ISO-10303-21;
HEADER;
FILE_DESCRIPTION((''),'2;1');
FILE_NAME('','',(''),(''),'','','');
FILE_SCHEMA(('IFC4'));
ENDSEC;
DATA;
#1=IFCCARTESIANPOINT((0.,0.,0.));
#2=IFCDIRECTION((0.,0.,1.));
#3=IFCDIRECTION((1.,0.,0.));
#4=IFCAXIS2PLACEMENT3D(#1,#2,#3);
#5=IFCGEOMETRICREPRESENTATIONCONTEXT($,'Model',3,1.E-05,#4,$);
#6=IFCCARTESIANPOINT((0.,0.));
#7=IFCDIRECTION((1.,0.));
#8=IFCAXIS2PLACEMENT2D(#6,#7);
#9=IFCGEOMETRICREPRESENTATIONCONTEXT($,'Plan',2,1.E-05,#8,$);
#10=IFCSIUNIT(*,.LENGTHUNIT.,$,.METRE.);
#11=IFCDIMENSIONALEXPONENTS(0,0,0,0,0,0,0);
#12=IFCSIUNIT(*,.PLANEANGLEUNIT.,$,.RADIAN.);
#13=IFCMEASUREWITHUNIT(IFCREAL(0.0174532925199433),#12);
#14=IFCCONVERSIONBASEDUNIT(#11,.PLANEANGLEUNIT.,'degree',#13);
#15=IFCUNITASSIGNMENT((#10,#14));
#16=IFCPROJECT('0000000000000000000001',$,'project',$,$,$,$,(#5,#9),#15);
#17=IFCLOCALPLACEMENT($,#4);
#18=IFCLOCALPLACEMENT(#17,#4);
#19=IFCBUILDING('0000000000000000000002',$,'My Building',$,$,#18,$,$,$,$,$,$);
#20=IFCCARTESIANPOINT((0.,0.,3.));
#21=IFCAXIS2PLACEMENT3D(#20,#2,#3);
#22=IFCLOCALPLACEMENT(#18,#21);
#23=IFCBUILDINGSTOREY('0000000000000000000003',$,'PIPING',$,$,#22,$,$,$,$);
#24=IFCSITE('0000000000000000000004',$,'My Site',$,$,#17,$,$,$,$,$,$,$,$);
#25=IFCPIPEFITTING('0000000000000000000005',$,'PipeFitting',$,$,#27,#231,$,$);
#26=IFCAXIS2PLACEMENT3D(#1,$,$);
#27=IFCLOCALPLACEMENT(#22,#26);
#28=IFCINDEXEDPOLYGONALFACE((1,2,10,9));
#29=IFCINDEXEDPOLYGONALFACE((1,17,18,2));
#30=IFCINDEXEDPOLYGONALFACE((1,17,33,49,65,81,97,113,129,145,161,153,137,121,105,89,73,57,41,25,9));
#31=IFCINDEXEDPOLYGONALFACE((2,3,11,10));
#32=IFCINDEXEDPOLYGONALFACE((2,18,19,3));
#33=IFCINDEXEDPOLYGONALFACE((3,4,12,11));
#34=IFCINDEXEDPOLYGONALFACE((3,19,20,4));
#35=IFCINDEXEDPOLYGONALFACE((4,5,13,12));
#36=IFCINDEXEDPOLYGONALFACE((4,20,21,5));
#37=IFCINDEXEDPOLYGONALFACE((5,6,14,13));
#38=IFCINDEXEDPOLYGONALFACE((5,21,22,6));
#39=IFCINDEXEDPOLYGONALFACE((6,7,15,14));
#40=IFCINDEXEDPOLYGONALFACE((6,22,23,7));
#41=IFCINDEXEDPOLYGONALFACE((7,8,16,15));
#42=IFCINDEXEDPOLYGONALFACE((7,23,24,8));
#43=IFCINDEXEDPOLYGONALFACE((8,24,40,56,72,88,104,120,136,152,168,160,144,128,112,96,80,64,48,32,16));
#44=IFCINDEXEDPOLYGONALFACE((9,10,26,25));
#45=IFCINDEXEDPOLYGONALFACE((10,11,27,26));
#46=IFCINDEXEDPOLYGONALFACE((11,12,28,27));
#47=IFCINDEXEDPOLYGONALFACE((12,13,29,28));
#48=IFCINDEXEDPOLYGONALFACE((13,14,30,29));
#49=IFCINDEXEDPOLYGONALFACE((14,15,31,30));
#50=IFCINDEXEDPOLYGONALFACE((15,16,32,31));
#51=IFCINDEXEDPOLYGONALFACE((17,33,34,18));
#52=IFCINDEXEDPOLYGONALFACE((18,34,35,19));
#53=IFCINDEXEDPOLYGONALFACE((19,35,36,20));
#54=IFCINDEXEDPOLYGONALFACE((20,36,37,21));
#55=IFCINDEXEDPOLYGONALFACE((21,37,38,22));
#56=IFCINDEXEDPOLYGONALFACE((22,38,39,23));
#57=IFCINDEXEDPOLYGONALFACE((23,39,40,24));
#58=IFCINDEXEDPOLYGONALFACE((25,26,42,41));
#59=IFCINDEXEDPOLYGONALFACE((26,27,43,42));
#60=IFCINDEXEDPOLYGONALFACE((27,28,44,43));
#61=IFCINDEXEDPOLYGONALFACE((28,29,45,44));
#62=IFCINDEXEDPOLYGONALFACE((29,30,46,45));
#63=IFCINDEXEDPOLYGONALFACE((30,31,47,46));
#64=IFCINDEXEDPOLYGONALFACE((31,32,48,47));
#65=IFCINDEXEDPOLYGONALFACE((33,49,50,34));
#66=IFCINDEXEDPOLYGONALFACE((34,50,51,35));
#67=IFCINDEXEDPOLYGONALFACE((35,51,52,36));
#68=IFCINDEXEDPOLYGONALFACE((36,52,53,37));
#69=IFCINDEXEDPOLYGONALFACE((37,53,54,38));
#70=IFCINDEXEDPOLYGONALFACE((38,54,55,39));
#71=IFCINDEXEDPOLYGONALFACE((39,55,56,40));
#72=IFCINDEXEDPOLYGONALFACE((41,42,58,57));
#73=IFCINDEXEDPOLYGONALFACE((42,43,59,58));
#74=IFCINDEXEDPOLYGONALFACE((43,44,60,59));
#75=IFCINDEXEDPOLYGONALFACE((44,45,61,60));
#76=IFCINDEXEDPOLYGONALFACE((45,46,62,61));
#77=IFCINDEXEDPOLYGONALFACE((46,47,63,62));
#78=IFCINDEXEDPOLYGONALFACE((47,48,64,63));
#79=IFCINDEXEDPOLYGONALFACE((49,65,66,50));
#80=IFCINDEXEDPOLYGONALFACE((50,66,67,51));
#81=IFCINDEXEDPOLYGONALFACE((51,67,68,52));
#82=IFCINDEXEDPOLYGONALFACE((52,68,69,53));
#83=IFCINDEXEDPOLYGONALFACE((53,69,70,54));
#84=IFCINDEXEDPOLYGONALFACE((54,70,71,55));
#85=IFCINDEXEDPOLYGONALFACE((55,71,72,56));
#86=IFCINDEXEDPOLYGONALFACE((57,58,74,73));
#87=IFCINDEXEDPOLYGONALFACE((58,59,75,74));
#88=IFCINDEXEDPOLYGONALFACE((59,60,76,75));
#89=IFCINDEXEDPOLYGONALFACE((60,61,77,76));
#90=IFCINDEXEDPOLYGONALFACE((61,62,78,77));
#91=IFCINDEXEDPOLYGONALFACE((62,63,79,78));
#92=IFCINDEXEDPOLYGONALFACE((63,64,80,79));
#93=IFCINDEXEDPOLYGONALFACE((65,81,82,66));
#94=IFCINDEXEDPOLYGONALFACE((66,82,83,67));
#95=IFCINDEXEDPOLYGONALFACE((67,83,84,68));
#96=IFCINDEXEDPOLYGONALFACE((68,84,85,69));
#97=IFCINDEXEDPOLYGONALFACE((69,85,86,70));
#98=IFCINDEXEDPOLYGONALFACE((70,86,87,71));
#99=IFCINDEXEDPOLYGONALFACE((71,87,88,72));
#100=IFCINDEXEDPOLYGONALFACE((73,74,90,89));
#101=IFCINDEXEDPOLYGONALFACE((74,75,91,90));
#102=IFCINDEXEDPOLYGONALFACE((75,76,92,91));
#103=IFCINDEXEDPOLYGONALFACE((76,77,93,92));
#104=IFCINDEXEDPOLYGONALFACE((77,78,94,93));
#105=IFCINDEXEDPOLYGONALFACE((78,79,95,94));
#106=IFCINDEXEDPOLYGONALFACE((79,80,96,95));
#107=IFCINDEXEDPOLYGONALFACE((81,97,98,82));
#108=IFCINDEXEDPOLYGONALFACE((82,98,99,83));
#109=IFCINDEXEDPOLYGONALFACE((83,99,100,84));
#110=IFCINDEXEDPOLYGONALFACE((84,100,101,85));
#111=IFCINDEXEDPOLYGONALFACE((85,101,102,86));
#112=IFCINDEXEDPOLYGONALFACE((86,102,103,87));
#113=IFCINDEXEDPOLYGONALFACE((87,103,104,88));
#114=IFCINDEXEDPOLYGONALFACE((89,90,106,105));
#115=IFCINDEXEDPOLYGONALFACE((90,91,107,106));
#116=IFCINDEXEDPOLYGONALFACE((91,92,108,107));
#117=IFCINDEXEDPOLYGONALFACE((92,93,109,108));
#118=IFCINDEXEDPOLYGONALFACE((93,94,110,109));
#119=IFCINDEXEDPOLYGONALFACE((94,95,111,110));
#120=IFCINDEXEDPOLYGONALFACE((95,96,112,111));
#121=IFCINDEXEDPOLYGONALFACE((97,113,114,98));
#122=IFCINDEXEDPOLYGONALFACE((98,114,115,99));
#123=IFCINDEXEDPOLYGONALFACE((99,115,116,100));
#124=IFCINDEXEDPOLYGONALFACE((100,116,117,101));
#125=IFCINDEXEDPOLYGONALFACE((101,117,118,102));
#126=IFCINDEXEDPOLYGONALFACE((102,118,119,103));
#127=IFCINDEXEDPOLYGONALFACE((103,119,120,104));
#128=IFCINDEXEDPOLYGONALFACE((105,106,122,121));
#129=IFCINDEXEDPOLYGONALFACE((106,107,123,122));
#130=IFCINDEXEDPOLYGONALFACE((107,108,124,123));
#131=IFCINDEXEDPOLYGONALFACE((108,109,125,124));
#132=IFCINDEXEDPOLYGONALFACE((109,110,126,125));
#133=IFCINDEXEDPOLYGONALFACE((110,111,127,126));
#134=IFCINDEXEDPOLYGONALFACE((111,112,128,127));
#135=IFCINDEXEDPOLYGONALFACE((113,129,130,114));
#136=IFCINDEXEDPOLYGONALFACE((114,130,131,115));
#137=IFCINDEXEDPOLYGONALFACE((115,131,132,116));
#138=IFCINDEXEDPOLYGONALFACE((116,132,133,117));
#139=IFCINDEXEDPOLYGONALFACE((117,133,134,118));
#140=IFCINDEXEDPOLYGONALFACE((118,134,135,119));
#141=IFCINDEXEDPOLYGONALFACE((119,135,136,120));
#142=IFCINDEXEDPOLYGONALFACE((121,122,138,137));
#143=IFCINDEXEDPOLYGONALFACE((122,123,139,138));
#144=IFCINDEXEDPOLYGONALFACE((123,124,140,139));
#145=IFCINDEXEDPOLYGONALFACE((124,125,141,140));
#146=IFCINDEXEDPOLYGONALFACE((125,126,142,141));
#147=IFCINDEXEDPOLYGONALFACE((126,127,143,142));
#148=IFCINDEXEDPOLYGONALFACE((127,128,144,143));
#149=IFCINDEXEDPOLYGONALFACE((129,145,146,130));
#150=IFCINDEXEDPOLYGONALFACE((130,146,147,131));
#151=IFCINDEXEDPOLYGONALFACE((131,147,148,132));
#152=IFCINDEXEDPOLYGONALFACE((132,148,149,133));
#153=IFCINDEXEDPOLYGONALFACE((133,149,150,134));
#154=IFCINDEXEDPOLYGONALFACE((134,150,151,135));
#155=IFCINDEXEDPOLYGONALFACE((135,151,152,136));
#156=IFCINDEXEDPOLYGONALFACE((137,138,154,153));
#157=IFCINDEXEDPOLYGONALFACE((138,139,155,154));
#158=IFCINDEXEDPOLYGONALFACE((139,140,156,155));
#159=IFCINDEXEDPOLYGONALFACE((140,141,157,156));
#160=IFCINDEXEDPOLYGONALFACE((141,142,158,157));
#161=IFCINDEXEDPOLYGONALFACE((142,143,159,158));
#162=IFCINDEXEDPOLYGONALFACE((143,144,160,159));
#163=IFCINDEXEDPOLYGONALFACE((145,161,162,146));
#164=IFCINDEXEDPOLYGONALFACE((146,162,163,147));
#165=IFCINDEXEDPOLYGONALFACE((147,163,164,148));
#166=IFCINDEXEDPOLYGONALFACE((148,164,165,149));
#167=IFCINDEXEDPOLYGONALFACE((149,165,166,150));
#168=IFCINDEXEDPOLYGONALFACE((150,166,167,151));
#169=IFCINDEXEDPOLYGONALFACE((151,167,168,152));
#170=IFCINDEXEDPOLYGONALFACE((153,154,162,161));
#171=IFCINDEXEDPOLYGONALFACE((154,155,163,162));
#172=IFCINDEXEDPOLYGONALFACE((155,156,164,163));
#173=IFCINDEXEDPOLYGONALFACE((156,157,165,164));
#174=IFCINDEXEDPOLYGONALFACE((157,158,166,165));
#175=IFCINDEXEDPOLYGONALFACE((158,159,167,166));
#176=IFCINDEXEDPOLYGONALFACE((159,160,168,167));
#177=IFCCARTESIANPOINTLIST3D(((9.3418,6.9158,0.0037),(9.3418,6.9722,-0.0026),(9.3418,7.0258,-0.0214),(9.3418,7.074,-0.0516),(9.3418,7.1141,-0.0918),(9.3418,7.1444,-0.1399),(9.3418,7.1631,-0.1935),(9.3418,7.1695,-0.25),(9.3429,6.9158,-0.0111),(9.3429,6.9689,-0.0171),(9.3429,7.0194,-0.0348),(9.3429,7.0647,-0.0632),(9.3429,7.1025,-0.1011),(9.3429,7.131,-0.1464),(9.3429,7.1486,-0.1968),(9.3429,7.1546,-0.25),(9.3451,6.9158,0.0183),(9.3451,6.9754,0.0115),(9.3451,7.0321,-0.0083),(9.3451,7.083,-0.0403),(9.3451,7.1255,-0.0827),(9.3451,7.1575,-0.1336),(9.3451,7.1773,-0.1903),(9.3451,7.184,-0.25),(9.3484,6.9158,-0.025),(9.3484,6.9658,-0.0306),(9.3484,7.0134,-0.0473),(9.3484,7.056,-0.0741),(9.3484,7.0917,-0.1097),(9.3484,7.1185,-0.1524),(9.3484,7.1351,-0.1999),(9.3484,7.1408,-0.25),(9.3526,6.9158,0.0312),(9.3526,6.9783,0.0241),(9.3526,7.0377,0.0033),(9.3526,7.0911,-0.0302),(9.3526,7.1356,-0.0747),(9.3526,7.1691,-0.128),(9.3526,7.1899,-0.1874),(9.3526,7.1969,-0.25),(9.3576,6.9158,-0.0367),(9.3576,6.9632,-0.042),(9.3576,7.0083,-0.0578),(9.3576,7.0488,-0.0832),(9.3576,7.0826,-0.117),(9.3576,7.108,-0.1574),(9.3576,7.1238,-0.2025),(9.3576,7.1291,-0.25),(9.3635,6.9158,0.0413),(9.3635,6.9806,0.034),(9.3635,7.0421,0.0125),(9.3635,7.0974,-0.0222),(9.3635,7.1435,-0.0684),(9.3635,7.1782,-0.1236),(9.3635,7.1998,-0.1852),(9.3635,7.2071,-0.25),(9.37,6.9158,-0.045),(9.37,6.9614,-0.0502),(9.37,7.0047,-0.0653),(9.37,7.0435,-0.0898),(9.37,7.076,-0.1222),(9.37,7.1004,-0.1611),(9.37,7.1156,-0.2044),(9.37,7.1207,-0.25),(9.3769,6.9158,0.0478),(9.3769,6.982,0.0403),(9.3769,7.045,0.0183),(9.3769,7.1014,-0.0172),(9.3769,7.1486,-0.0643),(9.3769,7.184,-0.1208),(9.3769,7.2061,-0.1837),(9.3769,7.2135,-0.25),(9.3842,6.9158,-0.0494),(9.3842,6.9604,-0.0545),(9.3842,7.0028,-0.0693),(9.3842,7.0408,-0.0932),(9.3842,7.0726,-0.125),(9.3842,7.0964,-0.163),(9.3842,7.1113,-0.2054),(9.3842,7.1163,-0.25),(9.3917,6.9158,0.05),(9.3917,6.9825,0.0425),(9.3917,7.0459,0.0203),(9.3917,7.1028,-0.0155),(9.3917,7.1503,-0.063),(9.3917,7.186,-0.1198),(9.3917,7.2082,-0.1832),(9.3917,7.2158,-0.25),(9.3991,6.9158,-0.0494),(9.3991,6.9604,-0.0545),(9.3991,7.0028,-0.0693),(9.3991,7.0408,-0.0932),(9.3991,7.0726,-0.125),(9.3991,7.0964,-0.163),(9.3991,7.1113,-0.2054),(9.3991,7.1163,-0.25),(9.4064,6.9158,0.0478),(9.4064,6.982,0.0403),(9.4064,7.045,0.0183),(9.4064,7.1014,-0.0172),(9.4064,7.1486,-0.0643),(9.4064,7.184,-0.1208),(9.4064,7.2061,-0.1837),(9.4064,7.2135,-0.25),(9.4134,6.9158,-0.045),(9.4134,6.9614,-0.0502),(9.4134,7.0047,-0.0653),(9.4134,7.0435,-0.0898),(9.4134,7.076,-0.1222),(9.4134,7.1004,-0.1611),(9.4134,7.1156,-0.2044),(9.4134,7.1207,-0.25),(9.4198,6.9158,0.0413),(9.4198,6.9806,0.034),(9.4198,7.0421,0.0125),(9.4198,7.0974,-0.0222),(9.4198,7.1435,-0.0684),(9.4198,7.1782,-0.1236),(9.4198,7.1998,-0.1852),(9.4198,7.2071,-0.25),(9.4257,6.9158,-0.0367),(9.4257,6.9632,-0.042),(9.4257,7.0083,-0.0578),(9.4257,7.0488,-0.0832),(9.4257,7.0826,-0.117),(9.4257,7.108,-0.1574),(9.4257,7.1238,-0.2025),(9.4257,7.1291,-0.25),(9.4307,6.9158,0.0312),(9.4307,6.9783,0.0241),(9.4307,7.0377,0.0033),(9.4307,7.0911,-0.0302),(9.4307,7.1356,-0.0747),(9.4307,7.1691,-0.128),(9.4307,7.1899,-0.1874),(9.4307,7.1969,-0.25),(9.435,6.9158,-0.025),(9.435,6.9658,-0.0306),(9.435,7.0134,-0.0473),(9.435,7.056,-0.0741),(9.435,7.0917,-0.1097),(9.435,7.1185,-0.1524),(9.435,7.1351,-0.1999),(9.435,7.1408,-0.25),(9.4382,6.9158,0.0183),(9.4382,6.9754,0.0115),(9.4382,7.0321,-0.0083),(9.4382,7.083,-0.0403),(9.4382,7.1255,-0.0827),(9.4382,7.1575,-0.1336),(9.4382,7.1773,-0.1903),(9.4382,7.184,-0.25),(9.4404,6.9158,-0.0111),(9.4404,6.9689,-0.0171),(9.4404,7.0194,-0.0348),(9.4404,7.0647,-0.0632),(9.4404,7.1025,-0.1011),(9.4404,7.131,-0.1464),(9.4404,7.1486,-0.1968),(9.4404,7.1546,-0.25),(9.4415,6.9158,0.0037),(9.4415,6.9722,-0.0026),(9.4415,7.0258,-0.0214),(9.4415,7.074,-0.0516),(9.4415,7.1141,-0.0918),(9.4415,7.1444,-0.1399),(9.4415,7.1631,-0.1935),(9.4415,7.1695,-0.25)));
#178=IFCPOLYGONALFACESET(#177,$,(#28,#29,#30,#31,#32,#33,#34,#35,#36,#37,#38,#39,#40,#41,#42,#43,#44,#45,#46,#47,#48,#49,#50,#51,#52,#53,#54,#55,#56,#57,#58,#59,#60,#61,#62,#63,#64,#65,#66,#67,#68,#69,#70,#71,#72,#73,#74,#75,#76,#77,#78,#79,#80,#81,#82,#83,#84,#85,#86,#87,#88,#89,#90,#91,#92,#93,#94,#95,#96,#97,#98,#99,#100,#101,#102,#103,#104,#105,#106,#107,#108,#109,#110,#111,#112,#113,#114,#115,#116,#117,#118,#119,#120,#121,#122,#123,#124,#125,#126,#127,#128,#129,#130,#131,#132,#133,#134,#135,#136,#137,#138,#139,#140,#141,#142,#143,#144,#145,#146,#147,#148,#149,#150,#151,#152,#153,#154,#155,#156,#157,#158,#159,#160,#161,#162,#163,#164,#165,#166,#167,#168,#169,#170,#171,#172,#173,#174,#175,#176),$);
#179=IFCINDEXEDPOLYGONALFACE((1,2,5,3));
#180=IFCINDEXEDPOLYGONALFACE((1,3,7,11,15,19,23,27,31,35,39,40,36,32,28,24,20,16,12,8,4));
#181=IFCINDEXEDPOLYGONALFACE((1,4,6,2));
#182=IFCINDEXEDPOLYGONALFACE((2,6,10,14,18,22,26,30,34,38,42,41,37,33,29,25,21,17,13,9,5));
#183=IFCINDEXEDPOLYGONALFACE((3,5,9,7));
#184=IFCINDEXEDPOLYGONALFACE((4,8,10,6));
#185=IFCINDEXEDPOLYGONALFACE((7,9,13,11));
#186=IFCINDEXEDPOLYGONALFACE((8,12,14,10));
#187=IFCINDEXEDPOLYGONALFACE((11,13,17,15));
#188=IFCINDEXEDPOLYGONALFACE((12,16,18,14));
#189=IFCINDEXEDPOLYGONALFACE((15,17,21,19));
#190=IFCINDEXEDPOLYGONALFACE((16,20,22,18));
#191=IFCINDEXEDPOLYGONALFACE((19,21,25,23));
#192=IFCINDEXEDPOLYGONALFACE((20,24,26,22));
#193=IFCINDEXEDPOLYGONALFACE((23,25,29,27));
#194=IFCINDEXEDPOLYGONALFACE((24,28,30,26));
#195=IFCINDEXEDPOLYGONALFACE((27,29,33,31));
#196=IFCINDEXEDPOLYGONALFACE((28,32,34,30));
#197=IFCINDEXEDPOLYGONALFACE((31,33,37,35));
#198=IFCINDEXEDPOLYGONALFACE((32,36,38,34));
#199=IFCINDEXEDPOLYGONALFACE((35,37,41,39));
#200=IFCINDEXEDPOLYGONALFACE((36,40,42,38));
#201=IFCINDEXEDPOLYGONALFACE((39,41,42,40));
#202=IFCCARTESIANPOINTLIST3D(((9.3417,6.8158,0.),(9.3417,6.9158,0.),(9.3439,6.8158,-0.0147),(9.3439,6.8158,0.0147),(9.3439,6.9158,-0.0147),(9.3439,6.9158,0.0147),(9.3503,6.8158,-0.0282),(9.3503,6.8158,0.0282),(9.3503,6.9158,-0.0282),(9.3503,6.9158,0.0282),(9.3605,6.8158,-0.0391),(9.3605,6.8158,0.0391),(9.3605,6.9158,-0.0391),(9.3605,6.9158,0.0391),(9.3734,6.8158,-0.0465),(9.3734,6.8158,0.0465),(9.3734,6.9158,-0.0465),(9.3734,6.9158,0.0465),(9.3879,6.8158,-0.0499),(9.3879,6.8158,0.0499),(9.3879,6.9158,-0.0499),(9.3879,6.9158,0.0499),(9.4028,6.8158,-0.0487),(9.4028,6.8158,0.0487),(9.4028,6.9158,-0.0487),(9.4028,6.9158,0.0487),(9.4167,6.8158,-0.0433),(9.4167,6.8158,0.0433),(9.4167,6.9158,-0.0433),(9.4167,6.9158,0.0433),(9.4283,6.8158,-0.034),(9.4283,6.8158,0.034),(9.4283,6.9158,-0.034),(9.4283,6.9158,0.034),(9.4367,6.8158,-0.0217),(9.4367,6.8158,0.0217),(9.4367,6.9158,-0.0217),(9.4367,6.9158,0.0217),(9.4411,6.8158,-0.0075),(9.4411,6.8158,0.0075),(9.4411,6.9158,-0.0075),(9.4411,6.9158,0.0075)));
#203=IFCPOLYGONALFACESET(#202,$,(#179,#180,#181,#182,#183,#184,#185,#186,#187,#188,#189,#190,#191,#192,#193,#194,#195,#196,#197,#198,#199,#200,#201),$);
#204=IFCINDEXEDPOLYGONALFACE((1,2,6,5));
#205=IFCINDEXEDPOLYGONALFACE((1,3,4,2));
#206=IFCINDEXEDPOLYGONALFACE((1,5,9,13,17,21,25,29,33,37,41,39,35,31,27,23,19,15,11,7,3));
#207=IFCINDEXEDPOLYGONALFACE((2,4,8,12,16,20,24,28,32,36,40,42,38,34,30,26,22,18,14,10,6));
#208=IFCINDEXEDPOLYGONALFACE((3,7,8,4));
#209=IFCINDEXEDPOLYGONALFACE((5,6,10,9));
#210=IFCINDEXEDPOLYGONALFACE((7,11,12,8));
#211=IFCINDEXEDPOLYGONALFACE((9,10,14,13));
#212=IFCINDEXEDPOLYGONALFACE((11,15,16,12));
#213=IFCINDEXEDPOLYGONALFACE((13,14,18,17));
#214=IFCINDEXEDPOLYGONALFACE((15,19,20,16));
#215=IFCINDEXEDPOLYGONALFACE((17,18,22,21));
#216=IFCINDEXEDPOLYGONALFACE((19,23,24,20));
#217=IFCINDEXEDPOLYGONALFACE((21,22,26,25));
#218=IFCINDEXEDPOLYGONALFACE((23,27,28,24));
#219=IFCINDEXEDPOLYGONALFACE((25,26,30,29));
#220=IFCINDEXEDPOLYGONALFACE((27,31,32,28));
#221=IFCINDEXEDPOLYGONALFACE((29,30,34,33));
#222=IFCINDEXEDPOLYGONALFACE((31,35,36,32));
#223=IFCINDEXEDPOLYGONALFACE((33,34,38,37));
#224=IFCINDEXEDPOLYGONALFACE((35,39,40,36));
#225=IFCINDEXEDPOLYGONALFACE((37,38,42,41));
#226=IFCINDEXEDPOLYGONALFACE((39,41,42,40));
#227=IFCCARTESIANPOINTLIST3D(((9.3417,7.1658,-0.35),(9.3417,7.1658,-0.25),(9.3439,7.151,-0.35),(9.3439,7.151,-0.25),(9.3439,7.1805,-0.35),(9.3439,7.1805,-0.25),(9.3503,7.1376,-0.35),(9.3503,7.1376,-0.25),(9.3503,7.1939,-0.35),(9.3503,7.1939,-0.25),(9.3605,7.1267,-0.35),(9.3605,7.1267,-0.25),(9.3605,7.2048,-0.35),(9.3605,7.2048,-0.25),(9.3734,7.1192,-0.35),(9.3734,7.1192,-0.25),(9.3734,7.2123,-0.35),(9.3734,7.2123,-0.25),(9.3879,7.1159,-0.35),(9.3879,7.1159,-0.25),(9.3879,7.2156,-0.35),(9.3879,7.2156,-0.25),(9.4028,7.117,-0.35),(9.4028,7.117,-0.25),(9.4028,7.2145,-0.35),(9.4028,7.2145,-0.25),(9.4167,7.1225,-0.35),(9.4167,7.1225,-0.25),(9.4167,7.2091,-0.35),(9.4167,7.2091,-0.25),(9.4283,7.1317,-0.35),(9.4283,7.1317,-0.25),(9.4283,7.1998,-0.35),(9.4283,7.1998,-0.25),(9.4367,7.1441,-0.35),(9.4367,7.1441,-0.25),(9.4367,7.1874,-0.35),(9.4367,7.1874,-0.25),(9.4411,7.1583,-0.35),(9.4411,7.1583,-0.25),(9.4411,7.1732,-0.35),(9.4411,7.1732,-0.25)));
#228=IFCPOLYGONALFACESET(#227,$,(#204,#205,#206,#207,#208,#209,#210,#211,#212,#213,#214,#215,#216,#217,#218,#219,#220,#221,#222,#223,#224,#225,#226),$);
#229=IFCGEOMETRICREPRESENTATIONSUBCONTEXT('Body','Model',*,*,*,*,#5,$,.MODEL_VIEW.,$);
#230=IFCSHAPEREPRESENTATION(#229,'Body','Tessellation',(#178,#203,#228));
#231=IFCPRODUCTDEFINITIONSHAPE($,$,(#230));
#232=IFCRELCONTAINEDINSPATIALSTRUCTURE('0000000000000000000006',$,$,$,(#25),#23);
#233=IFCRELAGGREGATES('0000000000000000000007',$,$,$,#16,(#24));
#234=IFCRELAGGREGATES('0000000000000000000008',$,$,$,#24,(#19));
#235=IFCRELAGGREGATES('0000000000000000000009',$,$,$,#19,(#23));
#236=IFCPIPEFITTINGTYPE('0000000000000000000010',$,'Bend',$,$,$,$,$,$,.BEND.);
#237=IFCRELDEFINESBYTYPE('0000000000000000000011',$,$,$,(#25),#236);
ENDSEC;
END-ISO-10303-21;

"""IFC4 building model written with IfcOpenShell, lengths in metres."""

from ifc_helpers import new_model, entity, si_unit, converted_unit, frame, origin_with_axes, origin_2d_with_axis, place, context, subcontext, project, spatial, circle, extrude, source, transform, mapped, type_object, type_shapes, element, save


model = new_model("IFC4")

# Units and contexts
model_context = context("Model", 3, precision=1e-05, world=origin_with_axes())
plan_context = context("Plan", 2, precision=1e-05, world=origin_2d_with_axis())
body_context = subcontext(model_context, "Body", "Model", "MODEL_VIEW")
ifc_project = project(units=[si_unit("LENGTHUNIT", "METRE"), converted_unit("PLANEANGLEUNIT", "degree", entity("IfcReal", 0.0174532925199433), si_unit("PLANEANGLEUNIT", "RADIAN"), dimensions=[0, 0, 0, 0, 0, 0, 0])], contexts=[model_context, plan_context])

# Site, building, storey
site_placement = place(None, origin_with_axes())
site = spatial("IfcSite", under=ifc_project, at=site_placement, Name="My Site")
building_placement = place(site_placement, origin_with_axes())
building = spatial("IfcBuilding", under=site, at=building_placement, Name="My Building")
storey_placement = place(building_placement, frame((0.0, 0.0, 3.0), z_axis=(0.0, 0.0, 1.0), x_axis=(1.0, 0.0, 0.0)))
storey = spatial("IfcBuildingStorey", under=building, at=storey_placement, Name="PIPING")

# Pipe fitting
pipe_fitting_type = type_object("IfcPipeFittingType", Name="Bend", PredefinedType="BEND")
shared_shape = source(origin_with_axes(), body_context, "Body", "SolidModel", [
    entity("IfcSweptDiskSolid", entity("IfcIndexedPolyCurve", entity("IfcCartesianPointList3D", [[0.0, 0.0, 0.1], [0.0, -0.0732, 0.2768], [0.0, -0.25, 0.35]]), [entity("IfcArcIndex", [1, 2, 3])]), 0.05),
    extrude(circle(Radius=0.05), origin_with_axes(), (0.0, 0.0, 1.0), 0.1),
    extrude(circle(Radius=0.05), frame((0.0, -0.25, 0.35), z_axis=(0.0, -1.0, 0.0), x_axis=(1.0, 0.0, 0.0)), (0.0, 0.0, 1.0), 0.1),
])
type_shapes(pipe_fitting_type, [shared_shape])
for number, where, z_axis, x_axis, name in (
    (1, (9.3917, 6.8158, 0.0), (0.0, 1.0, 0.0), (-1.0, 0.0, 0.0), "PipeFitting"),
):
    element("IfcPipeFitting", number, at=place(storey_placement, frame(where, z_axis=z_axis, x_axis=x_axis)), inside=storey, type_object=pipe_fitting_type, Name=name, context=body_context, shape_type="MappedRepresentation", body=[
        mapped(shared_shape, transform((0.0, 0.0, 0.0), x_axis=(1.0, 0.0, 0.0), y_axis=(0.0, 1.0, 0.0), z_axis=(0.0, 0.0, 1.0), scale=1.0)),
    ])

save(model, "model.ifc")
